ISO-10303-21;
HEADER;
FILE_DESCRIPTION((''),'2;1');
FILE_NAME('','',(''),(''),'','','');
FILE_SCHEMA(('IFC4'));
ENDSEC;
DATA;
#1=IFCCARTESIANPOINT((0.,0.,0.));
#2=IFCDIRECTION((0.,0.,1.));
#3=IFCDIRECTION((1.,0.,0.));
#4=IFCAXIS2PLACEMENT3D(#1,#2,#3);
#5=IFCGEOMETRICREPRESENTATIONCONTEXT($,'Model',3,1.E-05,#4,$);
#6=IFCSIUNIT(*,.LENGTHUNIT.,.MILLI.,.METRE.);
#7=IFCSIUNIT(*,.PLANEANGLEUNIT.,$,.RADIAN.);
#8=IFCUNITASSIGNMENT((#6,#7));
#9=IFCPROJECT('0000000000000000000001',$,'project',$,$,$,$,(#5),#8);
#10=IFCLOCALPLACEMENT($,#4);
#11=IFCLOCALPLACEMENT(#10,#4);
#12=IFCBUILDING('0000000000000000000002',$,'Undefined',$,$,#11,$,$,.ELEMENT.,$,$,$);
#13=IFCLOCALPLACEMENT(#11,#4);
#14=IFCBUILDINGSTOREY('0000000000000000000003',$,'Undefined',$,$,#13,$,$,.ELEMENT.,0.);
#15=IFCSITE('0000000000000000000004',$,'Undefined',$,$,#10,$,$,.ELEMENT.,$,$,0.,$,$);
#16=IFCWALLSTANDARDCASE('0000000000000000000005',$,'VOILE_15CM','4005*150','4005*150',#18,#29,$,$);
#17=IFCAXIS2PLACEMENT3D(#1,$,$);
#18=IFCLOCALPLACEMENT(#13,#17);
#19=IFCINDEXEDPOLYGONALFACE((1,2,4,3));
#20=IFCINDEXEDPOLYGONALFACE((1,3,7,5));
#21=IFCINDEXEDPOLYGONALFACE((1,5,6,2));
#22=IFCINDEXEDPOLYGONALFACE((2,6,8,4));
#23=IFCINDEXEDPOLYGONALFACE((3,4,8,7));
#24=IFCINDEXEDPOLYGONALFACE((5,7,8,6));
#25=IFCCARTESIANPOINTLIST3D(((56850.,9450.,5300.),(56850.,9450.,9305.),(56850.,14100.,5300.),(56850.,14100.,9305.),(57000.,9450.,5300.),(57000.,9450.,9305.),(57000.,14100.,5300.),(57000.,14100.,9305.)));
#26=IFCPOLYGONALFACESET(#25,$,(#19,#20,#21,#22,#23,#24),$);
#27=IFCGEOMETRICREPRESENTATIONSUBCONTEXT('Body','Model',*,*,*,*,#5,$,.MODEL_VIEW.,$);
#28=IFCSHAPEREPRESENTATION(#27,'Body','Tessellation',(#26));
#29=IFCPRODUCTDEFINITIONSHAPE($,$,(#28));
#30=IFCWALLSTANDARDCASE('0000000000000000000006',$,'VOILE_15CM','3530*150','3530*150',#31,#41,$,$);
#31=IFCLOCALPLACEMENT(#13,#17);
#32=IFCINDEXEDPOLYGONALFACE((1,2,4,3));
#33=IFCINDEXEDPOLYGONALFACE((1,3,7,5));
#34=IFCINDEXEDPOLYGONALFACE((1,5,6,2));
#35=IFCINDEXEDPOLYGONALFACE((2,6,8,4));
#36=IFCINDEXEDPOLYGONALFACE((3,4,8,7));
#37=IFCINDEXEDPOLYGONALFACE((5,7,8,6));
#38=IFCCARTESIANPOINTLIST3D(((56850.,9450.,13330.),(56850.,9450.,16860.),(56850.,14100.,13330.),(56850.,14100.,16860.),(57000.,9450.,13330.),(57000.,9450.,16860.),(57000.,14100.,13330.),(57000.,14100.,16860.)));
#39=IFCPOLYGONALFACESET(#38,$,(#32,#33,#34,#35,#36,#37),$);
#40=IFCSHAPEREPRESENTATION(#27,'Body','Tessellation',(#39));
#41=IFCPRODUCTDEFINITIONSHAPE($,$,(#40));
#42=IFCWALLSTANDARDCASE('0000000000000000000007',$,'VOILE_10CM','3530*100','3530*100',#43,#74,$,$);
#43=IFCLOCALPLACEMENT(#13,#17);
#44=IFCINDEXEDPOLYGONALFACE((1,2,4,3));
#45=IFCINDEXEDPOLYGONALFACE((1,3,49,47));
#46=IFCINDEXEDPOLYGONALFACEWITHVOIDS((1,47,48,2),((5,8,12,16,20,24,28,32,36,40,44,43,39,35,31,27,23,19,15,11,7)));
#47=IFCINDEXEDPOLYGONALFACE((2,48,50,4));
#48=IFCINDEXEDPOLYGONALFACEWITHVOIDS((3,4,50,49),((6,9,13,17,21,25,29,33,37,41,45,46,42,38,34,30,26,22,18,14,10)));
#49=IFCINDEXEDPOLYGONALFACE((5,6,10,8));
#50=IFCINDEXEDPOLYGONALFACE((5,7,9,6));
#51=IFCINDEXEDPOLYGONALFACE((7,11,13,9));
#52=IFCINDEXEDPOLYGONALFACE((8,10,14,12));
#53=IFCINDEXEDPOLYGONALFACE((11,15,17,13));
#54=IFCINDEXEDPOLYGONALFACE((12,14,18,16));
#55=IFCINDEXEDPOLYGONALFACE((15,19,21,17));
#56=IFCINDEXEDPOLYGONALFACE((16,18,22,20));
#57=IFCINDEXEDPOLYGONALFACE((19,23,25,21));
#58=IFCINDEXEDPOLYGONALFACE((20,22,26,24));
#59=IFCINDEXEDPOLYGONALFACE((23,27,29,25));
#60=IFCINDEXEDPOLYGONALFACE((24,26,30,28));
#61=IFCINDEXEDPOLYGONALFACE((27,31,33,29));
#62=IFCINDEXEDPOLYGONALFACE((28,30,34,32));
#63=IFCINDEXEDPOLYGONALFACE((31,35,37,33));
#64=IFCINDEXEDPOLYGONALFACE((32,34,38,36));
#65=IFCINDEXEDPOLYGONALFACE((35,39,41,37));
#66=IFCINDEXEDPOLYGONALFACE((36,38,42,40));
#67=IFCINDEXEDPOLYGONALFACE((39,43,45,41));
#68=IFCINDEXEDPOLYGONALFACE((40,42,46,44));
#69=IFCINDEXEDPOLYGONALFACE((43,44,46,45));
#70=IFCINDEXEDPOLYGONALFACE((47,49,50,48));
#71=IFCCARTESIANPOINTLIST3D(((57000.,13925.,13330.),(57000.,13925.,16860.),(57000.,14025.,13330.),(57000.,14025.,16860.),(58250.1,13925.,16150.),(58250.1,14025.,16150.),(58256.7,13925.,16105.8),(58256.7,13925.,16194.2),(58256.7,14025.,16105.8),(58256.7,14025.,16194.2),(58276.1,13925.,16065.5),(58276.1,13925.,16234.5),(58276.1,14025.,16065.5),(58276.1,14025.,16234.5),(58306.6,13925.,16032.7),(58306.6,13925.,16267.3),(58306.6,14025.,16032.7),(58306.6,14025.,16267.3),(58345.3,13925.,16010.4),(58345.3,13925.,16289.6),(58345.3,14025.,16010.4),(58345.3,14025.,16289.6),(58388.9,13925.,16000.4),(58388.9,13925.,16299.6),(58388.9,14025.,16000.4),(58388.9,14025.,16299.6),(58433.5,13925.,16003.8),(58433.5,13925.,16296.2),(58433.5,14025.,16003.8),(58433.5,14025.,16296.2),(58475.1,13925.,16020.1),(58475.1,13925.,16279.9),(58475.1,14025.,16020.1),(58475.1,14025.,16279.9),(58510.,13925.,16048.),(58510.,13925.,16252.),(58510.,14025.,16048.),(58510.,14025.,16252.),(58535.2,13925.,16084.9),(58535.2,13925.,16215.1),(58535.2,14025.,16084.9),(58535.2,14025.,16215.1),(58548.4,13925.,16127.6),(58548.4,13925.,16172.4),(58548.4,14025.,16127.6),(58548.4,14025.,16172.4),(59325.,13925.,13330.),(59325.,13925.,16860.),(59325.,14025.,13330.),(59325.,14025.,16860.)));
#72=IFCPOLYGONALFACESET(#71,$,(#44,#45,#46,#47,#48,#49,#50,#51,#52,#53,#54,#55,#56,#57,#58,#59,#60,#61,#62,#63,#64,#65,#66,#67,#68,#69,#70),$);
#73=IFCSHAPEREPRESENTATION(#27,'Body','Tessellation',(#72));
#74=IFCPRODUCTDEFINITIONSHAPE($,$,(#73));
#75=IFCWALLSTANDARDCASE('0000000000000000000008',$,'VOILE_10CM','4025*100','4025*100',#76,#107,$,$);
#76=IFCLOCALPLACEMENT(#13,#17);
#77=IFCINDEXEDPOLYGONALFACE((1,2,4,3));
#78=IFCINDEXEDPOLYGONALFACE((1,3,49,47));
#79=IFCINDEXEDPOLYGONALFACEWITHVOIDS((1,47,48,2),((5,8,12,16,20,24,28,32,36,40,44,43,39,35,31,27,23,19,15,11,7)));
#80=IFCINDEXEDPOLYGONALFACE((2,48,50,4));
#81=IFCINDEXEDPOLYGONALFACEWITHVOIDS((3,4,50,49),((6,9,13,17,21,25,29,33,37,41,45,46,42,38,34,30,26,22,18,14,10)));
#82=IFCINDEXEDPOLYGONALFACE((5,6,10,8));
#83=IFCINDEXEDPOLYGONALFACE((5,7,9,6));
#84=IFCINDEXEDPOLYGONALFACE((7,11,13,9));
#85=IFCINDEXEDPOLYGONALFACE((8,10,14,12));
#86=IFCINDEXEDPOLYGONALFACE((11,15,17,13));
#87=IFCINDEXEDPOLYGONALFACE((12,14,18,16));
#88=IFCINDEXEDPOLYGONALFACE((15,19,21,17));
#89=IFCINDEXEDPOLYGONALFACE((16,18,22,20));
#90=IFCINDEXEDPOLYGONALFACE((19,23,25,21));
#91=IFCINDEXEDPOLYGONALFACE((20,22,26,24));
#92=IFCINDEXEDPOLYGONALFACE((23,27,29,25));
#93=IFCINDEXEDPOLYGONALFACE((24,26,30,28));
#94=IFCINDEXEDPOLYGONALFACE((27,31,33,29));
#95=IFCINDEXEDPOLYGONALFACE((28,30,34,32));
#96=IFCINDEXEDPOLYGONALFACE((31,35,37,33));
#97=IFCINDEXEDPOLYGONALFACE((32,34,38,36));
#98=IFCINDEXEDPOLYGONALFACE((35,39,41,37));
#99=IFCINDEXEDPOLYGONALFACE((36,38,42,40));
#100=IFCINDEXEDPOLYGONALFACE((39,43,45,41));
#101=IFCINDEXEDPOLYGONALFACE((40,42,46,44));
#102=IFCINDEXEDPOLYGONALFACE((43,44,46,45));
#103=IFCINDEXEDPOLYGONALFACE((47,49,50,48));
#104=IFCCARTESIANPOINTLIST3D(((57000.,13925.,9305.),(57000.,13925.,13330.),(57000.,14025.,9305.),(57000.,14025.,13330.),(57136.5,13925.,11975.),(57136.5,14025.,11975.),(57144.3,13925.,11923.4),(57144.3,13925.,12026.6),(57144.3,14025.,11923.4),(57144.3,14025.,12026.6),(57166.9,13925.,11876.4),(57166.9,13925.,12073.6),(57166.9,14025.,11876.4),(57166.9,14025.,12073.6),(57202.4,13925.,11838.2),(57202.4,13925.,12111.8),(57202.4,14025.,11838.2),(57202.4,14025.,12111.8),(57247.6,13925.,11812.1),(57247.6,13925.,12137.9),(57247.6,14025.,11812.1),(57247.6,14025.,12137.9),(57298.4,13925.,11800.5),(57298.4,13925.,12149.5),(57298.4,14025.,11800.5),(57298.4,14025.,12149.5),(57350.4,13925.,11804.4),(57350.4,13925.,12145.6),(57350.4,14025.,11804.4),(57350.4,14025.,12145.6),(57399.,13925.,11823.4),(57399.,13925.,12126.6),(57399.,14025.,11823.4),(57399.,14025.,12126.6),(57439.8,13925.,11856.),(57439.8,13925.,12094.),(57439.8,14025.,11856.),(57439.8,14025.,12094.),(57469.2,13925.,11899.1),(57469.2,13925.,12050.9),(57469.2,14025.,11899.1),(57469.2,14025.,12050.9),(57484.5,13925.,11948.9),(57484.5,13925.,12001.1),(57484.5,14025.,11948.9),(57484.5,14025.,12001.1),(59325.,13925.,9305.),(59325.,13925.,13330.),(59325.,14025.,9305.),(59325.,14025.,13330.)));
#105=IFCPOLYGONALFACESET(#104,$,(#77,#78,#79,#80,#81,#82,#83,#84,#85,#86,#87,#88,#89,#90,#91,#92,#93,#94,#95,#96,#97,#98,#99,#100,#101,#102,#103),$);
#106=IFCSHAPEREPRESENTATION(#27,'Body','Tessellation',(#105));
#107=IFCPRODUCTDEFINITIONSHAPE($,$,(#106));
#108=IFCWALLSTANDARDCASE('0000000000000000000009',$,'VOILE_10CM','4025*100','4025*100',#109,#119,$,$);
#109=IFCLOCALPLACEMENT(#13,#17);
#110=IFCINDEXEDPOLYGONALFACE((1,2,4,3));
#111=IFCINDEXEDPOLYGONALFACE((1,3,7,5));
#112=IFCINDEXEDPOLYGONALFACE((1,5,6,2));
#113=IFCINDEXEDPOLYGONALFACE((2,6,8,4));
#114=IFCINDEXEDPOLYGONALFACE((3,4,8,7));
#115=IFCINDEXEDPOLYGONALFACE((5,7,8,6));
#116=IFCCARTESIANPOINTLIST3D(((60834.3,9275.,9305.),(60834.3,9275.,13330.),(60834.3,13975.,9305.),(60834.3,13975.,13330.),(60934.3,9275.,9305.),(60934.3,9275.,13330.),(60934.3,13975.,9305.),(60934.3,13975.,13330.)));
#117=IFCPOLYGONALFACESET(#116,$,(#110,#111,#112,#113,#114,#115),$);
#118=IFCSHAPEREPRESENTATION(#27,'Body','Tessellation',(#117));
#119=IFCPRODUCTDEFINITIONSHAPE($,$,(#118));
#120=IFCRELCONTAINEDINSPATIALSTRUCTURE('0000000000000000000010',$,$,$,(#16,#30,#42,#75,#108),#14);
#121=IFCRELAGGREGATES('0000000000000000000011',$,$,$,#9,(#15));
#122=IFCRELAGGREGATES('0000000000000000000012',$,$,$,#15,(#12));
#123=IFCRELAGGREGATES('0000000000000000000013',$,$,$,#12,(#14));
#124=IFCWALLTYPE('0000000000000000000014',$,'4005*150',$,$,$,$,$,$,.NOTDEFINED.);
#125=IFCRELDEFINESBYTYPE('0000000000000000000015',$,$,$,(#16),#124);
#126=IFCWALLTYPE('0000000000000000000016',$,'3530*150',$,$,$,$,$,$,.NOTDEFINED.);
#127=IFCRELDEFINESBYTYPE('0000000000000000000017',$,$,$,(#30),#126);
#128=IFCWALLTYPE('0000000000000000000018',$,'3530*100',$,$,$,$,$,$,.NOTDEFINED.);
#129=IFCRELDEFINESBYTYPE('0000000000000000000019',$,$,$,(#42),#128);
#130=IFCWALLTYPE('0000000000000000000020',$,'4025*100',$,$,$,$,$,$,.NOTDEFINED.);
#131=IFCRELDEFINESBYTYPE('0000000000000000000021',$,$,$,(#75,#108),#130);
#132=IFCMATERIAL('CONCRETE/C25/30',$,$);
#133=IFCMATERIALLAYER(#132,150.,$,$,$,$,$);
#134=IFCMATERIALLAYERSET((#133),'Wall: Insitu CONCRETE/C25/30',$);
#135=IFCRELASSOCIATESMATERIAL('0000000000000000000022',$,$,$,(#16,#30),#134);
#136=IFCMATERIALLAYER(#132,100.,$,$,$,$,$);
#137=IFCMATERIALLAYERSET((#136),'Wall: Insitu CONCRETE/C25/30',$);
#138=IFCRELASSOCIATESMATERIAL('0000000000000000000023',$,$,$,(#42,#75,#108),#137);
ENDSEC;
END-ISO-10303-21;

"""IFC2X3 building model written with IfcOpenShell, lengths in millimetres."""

from ifc_helpers import new_model, si_unit, frame, frame_2d, origin_with_axes, origin_2d_with_axis, place, context, subcontext, project, spatial, rectangle, circle, extrude, boolean, material, layer, layer_set, layer_usage, type_object, element, save


model = new_model("IFC2X3")

# Units and contexts
model_context = context("Model", 3, precision=1e-05, world=origin_with_axes())
body_context = subcontext(model_context, "Body", "Model", "MODEL_VIEW")
ifc_project = project(units=[si_unit("LENGTHUNIT", "METRE", prefix="MILLI"), si_unit("PLANEANGLEUNIT", "RADIAN")], contexts=[model_context])

# Site, building, storey
site_placement = place(None, origin_with_axes())
site = spatial("IfcSite", under=ifc_project, at=site_placement, Name="Undefined", CompositionType="ELEMENT", RefElevation=0.0)
building_placement = place(site_placement, origin_with_axes())
building = spatial("IfcBuilding", under=site, at=building_placement, Name="Undefined", CompositionType="ELEMENT")
storey_placement = place(building_placement, origin_with_axes())
storey = spatial("IfcBuildingStorey", under=building, at=storey_placement, Name="Undefined", CompositionType="ELEMENT", Elevation=0.0)

# Shared definitions
ifc_material_1 = material(Name="CONCRETE/C25/30")

# Walls
ifc_layer_1 = layer(ifc_material_1, 150.0)
ifc_layer_set_1 = layer_set([ifc_layer_1], Name="Wall: Insitu CONCRETE/C25/30")
ifc_layer_usage_1 = layer_usage(ifc_layer_set_1, "AXIS2", "POSITIVE", -75.0)
wall_type_1 = type_object("IfcWallType", Name="4005*150", PredefinedType="NOTDEFINED")
wall_1_placement = place(storey_placement, frame((56925.0, 14100.0, 5300.0), z_axis=(0.0, 0.0, 1.0), x_axis=(0.0, -1.0, 0.0)))
element("IfcWallStandardCase", 1, at=wall_1_placement, inside=storey, type_object=wall_type_1, material=ifc_layer_usage_1, Name="VOILE_15CM", Description="4005*150", ObjectType="4005*150", context=body_context, shape_type="SweptSolid", body=[
    extrude(rectangle(XDim=4650.0, YDim=150.0, at=frame_2d((0.0, 2325.0), x_axis=(0.0, -1.0))), frame((0.0, 0.0, 0.0), z_axis=(0.0, 0.0, 1.0), x_axis=(0.0, -1.0, 0.0)), (0.0, 0.0, 1.0), 4005.0),
])
wall_type_2 = type_object("IfcWallType", Name="3530*150", PredefinedType="NOTDEFINED")
ifc_layer_usage_2 = layer_usage(ifc_layer_set_1, "AXIS2", "POSITIVE", -75.0)
wall_2_placement = place(storey_placement, frame((56925.0, 14100.0, 13330.0), z_axis=(0.0, 0.0, 1.0), x_axis=(0.0, -1.0, 0.0)))
element("IfcWallStandardCase", 2, at=wall_2_placement, inside=storey, type_object=wall_type_2, material=ifc_layer_usage_2, Name="VOILE_15CM", Description="3530*150", ObjectType="3530*150", context=body_context, shape_type="SweptSolid", body=[
    extrude(rectangle(XDim=4650.0, YDim=150.0, at=frame_2d((0.0, 2325.0), x_axis=(0.0, -1.0))), frame((0.0, 0.0, 0.0), z_axis=(0.0, 0.0, 1.0), x_axis=(0.0, -1.0, 0.0)), (0.0, 0.0, 1.0), 3530.0),
])
ifc_layer_2 = layer(ifc_material_1, 100.0)
ifc_layer_set_2 = layer_set([ifc_layer_2], Name="Wall: Insitu CONCRETE/C25/30")
ifc_layer_usage_3 = layer_usage(ifc_layer_set_2, "AXIS2", "POSITIVE", -50.0)
wall_type_3 = type_object("IfcWallType", Name="3530*100", PredefinedType="NOTDEFINED")
wall_3_placement = place(storey_placement, frame((57000.0, 13975.0, 13330.0), z_axis=(0.0, 0.0, 1.0), x_axis=(1.0, 0.0, 0.0)))
element("IfcWallStandardCase", 3, at=wall_3_placement, inside=storey, type_object=wall_type_3, material=ifc_layer_usage_3, Name="VOILE_10CM", Description="3530*100", ObjectType="3530*100", context=body_context, shape_type="CSG", body=[
    boolean("DIFFERENCE", extrude(rectangle(XDim=2325.0, YDim=100.0, at=frame_2d((0.0, 1162.5), x_axis=(0.0, -1.0))), frame((0.0, 0.0, 0.0), z_axis=(0.0, 0.0, 1.0), x_axis=(0.0, -1.0, 0.0)), (0.0, 0.0, 1.0), 3530.0), extrude(circle(Radius=150.0, at=origin_2d_with_axis()), frame((1400.1, -60.0, 2820.0), z_axis=(0.0, 1.0, 0.0), x_axis=(-1.0, 0.0, 0.0)), (0.0, 0.0, 1.0), 120.0)),
])
ifc_layer_usage_4 = layer_usage(ifc_layer_set_2, "AXIS2", "POSITIVE", -50.0)
wall_type_4 = type_object("IfcWallType", Name="4025*100", PredefinedType="NOTDEFINED")
wall_4_placement = place(storey_placement, frame((57000.0, 13975.0, 9305.0), z_axis=(0.0, 0.0, 1.0), x_axis=(1.0, 0.0, 0.0)))
element("IfcWallStandardCase", 4, at=wall_4_placement, inside=storey, type_object=wall_type_4, material=ifc_layer_usage_4, Name="VOILE_10CM", Description="4025*100", ObjectType="4025*100", context=body_context, shape_type="CSG", body=[
    boolean("DIFFERENCE", extrude(rectangle(XDim=2325.0, YDim=100.0, at=frame_2d((0.0, 1162.5), x_axis=(0.0, -1.0))), frame((0.0, 0.0, 0.0), z_axis=(0.0, 0.0, 1.0), x_axis=(0.0, -1.0, 0.0)), (0.0, 0.0, 1.0), 4025.0), extrude(circle(Radius=175.0, at=origin_2d_with_axis()), frame((311.5, -60.0, 2670.0), z_axis=(0.0, 1.0, 0.0), x_axis=(-1.0, 0.0, 0.0)), (0.0, 0.0, 1.0), 120.0)),
])
ifc_layer_usage_5 = layer_usage(ifc_layer_set_2, "AXIS2", "POSITIVE", -50.0)
wall_5_placement = place(storey_placement, frame((60884.3, 13975.0, 9305.0), z_axis=(0.0, 0.0, 1.0), x_axis=(0.0, -1.0, 0.0)))
element("IfcWallStandardCase", 5, at=wall_5_placement, inside=storey, type_object=wall_type_4, material=ifc_layer_usage_5, Name="VOILE_10CM", Description="4025*100", ObjectType="4025*100", context=body_context, shape_type="SweptSolid", body=[
    extrude(rectangle(XDim=4700.0, YDim=100.0, at=frame_2d((0.0, 2350.0), x_axis=(0.0, -1.0))), frame((0.0, 0.0, 0.0), z_axis=(0.0, 0.0, 1.0), x_axis=(0.0, -1.0, 0.0)), (0.0, 0.0, 1.0), 4025.0),
])

save(model, "model.ifc")
